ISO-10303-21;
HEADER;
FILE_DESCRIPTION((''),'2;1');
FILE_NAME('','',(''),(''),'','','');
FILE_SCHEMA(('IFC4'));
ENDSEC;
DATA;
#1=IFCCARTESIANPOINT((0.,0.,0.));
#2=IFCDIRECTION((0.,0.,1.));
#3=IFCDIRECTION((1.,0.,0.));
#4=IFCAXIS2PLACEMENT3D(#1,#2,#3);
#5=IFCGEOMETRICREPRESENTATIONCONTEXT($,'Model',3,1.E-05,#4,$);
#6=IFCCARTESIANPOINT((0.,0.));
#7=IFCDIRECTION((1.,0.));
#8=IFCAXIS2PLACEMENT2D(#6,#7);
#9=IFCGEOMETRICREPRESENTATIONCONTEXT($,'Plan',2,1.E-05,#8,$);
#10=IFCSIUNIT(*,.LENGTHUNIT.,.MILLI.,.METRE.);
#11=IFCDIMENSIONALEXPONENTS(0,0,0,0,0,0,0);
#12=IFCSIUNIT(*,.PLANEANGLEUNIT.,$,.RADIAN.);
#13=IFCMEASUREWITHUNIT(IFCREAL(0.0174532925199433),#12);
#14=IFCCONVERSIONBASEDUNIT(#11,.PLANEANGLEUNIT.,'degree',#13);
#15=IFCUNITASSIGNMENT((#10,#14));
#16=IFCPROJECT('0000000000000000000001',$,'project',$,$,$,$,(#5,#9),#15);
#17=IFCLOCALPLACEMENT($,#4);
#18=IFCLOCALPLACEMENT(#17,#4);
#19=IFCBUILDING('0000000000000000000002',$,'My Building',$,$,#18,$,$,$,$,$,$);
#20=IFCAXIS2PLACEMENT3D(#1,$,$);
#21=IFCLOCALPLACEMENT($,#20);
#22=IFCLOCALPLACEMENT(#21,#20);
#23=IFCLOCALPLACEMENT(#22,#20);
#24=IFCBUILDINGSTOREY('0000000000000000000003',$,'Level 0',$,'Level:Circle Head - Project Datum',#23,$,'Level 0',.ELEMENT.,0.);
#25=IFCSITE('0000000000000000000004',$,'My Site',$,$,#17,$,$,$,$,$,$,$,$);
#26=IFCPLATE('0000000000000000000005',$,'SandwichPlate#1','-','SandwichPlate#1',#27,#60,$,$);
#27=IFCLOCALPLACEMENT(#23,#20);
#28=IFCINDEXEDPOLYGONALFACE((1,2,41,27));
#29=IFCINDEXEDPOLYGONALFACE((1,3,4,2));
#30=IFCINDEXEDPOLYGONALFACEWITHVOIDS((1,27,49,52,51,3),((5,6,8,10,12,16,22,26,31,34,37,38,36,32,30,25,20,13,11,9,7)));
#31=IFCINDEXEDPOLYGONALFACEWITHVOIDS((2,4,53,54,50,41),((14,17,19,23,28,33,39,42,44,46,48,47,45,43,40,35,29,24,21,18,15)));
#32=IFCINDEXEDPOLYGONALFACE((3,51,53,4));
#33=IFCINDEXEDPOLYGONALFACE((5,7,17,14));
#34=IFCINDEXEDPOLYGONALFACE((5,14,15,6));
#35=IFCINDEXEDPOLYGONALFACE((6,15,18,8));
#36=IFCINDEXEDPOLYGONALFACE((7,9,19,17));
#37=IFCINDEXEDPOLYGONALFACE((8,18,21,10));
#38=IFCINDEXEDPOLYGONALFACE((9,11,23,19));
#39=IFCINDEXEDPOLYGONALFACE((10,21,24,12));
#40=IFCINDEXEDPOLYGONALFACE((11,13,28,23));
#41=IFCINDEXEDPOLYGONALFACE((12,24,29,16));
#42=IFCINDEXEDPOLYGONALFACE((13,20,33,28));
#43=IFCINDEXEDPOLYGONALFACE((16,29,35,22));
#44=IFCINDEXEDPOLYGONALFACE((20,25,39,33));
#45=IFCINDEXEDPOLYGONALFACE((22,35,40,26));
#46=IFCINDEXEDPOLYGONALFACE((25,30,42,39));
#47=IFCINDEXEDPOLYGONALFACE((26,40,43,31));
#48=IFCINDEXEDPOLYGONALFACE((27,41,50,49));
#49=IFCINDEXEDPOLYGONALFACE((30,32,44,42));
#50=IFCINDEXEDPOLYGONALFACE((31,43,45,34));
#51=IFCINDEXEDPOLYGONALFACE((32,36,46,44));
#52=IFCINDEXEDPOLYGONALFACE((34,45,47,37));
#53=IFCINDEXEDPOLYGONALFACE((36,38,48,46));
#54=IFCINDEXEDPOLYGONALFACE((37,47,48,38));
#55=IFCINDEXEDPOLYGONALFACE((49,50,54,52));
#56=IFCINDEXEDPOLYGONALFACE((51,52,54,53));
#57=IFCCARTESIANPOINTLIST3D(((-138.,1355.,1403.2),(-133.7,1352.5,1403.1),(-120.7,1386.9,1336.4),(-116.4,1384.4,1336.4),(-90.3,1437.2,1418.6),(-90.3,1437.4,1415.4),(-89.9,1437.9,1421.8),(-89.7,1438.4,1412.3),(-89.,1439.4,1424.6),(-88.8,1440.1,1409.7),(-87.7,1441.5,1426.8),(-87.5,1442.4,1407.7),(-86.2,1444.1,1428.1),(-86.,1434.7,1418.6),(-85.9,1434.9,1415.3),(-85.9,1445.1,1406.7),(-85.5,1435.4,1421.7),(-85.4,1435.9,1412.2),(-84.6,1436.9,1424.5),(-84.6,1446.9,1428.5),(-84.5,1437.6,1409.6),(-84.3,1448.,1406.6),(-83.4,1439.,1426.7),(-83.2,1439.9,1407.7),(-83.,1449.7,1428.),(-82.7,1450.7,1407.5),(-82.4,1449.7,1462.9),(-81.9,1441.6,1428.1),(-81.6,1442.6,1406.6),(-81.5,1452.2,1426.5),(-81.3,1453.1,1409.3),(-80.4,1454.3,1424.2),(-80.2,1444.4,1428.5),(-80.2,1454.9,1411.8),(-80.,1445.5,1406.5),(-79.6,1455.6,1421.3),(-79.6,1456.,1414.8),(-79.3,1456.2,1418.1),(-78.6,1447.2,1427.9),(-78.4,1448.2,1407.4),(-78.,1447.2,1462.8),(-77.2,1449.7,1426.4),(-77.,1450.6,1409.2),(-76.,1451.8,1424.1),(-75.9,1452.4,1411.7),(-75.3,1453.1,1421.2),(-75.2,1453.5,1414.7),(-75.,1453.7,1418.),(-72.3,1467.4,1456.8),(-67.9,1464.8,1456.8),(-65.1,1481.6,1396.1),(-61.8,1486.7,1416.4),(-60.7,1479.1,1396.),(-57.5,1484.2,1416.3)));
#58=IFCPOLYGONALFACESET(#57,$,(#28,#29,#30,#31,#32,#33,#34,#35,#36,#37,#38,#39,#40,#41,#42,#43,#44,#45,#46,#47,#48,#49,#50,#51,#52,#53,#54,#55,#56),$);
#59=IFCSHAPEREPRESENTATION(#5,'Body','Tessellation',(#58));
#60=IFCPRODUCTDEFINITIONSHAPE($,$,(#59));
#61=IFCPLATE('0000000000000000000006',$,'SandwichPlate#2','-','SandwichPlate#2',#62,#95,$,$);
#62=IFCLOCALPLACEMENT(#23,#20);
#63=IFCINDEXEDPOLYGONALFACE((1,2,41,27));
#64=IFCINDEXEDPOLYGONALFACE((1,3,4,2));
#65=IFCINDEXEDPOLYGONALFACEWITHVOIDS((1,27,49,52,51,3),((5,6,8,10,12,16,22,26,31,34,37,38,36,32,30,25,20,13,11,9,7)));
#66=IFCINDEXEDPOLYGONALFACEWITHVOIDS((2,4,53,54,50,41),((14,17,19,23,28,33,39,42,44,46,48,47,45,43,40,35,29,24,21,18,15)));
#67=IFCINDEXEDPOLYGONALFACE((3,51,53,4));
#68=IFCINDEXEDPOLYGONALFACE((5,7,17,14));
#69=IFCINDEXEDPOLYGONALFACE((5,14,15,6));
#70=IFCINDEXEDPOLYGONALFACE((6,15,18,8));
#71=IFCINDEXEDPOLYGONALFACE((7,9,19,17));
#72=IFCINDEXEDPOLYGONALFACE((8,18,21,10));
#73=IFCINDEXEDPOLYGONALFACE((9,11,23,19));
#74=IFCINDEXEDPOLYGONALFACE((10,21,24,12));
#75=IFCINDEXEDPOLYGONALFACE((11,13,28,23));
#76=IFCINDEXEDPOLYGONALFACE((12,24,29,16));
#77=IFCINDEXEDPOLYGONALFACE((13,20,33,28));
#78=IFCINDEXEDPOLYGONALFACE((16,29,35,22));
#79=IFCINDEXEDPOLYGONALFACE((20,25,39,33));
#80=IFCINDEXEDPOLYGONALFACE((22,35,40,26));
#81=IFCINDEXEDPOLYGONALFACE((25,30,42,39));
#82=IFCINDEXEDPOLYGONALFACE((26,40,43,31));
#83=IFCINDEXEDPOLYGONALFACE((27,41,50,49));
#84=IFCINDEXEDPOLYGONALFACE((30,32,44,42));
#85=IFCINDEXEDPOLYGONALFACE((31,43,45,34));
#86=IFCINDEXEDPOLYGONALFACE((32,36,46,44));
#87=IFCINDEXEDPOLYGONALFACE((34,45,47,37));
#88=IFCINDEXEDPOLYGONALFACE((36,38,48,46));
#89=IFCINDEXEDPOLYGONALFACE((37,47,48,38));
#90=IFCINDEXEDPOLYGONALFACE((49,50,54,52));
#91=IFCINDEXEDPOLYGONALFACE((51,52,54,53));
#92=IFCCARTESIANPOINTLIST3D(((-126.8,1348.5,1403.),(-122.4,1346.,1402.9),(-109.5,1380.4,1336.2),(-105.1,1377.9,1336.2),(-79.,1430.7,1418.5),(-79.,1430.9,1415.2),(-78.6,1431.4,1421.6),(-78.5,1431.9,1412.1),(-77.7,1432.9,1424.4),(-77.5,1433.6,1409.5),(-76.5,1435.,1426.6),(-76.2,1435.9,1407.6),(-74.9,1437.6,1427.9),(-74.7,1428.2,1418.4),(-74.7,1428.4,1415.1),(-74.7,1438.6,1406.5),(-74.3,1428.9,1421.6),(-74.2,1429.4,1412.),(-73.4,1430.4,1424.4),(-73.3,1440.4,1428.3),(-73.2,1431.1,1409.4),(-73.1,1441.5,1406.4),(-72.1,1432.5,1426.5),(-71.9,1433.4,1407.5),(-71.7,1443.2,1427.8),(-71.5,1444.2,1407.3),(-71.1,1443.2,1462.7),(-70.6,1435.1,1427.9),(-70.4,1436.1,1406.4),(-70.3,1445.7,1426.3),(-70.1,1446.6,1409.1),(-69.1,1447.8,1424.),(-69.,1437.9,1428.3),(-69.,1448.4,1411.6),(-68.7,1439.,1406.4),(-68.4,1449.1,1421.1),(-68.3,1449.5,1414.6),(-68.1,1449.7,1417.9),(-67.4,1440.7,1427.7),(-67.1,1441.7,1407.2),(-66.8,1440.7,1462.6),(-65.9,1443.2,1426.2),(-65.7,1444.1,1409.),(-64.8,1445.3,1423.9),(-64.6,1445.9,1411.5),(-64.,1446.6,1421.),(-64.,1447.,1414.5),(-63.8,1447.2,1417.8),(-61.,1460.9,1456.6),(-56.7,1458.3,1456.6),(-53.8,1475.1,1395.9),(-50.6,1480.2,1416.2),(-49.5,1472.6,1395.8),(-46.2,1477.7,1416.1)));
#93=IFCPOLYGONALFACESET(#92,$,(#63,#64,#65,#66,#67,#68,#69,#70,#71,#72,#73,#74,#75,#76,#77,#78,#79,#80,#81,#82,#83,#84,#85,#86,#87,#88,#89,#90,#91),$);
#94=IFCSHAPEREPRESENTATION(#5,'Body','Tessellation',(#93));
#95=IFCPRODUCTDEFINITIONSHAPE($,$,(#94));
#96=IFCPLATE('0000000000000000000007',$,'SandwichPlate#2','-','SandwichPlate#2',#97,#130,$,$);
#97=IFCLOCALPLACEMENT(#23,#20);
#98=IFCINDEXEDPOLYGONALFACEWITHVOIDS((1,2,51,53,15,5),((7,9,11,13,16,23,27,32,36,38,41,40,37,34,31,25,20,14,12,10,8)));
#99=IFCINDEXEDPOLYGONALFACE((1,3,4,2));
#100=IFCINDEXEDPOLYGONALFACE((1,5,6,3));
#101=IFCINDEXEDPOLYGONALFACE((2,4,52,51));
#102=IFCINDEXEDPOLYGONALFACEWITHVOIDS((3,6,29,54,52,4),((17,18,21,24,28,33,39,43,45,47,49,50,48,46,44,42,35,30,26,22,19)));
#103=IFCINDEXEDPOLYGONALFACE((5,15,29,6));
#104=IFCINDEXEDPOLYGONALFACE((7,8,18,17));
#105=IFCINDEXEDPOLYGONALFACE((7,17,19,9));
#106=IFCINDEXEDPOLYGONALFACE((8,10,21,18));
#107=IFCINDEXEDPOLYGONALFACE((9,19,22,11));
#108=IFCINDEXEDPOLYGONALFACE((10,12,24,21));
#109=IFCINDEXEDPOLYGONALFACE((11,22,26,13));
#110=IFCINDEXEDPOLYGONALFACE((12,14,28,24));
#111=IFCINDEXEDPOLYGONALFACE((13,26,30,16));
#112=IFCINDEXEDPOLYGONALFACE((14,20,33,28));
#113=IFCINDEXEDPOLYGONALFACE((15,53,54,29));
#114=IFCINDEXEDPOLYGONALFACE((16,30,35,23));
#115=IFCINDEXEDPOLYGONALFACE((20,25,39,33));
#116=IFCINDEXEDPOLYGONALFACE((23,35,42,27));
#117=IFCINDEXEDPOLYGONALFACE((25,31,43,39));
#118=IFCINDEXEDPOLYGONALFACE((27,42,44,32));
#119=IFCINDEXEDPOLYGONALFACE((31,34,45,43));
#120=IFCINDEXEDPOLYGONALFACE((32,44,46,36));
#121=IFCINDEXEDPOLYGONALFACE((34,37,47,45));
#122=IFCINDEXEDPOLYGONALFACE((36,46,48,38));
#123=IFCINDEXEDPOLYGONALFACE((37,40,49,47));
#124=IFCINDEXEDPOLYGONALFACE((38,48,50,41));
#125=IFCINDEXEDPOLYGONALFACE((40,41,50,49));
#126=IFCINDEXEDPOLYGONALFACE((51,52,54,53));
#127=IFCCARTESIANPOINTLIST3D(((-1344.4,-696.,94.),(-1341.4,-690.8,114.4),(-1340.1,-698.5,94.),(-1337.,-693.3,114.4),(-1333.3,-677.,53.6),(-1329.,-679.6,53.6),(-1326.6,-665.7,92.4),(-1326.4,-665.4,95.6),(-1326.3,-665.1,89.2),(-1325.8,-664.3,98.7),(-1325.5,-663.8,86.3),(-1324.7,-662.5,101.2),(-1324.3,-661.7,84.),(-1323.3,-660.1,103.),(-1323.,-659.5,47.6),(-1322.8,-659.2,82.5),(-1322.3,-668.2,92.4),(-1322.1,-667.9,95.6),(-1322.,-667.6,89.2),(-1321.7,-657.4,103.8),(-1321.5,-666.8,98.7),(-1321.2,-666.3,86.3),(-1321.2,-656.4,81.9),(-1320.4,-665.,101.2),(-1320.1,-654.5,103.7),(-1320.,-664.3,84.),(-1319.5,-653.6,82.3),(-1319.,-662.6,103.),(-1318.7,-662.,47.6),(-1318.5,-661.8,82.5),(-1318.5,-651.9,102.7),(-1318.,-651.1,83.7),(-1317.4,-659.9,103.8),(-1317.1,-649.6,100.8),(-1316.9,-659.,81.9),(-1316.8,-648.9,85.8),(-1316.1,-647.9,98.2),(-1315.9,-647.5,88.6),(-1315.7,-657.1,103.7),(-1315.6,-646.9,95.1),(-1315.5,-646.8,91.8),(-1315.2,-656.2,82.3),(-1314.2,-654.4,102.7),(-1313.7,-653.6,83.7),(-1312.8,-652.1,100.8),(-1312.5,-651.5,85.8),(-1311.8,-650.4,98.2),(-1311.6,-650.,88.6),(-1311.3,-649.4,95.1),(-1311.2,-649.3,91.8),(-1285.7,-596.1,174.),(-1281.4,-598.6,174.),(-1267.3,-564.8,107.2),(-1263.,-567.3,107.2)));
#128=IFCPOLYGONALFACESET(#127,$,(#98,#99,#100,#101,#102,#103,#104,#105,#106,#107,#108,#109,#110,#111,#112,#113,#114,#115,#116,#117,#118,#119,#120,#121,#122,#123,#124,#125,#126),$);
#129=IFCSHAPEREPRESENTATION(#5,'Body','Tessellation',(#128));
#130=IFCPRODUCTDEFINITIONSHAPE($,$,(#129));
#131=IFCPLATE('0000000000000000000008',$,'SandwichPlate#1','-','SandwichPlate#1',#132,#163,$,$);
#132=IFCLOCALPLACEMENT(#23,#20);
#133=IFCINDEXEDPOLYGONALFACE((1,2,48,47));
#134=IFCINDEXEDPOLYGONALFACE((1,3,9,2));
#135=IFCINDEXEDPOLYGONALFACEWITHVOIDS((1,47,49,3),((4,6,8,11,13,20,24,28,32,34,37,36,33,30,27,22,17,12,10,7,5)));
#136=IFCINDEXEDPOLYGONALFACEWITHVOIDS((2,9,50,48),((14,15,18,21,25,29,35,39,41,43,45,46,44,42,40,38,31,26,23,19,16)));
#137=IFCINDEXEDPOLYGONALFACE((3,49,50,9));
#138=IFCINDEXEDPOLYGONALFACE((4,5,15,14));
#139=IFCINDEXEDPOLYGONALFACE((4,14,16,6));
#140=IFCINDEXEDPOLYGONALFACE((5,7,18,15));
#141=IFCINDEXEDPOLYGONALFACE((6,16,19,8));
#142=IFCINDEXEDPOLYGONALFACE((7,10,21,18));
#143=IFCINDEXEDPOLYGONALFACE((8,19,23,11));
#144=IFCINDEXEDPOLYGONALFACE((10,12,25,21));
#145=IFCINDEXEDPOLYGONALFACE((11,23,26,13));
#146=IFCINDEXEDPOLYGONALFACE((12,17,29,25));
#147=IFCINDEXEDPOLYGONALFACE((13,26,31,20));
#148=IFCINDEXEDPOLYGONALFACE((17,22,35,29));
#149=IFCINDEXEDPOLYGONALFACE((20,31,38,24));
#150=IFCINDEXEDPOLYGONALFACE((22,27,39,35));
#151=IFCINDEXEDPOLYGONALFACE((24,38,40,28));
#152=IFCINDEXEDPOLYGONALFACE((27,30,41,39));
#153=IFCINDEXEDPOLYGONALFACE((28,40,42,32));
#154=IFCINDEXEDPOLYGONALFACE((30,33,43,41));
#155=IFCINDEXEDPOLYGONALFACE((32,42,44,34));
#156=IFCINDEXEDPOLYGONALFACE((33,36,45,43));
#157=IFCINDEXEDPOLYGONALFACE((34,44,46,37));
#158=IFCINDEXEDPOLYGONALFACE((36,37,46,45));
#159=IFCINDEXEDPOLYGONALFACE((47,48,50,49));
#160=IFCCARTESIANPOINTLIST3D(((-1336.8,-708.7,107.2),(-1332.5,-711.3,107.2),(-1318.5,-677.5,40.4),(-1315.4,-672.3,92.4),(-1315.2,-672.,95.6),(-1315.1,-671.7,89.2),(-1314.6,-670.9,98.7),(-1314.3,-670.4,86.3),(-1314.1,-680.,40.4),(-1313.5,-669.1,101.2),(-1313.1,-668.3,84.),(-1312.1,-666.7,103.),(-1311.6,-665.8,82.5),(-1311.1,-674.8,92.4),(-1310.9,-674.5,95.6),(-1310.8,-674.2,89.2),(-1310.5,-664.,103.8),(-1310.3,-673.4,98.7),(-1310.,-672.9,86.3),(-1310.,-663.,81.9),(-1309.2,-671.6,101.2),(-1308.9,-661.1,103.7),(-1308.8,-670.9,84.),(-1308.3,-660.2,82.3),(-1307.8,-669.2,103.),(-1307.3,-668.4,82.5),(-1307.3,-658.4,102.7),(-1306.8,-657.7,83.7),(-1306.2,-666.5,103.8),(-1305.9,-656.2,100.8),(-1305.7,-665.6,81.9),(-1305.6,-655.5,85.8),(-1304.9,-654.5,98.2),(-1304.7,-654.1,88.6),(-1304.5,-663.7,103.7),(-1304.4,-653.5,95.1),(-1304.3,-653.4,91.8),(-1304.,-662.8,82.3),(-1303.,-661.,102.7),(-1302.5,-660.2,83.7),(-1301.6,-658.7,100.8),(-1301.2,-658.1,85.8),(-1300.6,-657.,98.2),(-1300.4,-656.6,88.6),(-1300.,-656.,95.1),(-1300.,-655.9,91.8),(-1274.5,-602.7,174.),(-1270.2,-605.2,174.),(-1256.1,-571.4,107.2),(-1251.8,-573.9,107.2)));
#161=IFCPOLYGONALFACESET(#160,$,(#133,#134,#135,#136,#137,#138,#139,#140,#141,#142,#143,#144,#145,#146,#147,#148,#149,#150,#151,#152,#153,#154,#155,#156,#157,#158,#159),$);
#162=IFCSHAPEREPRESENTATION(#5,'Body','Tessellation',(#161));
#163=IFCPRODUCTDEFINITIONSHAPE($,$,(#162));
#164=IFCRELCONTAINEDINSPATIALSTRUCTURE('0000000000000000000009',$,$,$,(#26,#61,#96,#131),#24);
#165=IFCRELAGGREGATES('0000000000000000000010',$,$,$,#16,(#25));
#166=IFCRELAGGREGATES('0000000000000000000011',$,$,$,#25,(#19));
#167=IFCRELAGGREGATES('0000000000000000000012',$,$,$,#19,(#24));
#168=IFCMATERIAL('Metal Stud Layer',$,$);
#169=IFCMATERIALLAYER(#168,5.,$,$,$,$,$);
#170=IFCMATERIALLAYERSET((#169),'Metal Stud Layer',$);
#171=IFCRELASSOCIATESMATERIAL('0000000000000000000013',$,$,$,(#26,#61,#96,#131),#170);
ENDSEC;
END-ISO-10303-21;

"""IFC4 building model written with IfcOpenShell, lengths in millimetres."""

from ifc_helpers import new_model, entity, si_unit, converted_unit, frame, origin, origin_with_axes, origin_2d_with_axis, place, context, project, spatial, polyline, circle, outline, extrude, material, layer, layer_set, element, save


model = new_model("IFC4")

# Units and contexts
model_context = context("Model", 3, precision=1e-05, world=origin_with_axes())
plan_context = context("Plan", 2, precision=1e-05, world=origin_2d_with_axis())
ifc_project = project(units=[si_unit("LENGTHUNIT", "METRE", prefix="MILLI"), converted_unit("PLANEANGLEUNIT", "degree", entity("IfcReal", 0.0174532925199433), si_unit("PLANEANGLEUNIT", "RADIAN"), dimensions=[0, 0, 0, 0, 0, 0, 0])], contexts=[model_context, plan_context])

# Site, building, storey
site_placement = place(None, origin_with_axes())
site = spatial("IfcSite", under=ifc_project, at=site_placement, Name="My Site")
building_placement = place(site_placement, origin_with_axes())
building = spatial("IfcBuilding", under=site, at=building_placement, Name="My Building")
placement_1 = place(None, origin())
placement_2 = place(placement_1, origin())
storey_placement = place(placement_2, origin())
storey = spatial("IfcBuildingStorey", under=building, at=storey_placement, Name="Level 0", ObjectType="Level:Circle Head - Project Datum", LongName="Level 0", CompositionType="ELEMENT", Elevation=0.0)

# Plates, openings
ifc_material_1 = material(Name="Metal Stud Layer")
ifc_layer_1 = layer(ifc_material_1, 5.0)
ifc_layer_set_1 = layer_set([ifc_layer_1], Name="Metal Stud Layer")
plate_1_placement = place(storey_placement, frame((-58.4, 1493.0, 1403.2), z_axis=(0.865935, -0.499948, -0.014432), x_axis=(-0.22762, -0.419615, 0.878699)))
plate_1 = element("IfcPlate", 1, at=plate_1_placement, inside=storey, material=ifc_layer_set_1, Name="SandwichPlate#1", Description="-", ObjectType="SandwichPlate#1", context=model_context, shape_type="SweptSolid", body=[
    extrude(outline(polyline([(0.0, 0.0), (76.0, 0.0), (76.0, 140.0), (0.0, 140.0), (0.0, 0.0)])), origin_with_axes(), (0.0, 0.0, 1.0), 5.0),
])
opening_1_placement = place(plate_1_placement, frame((0.0, 0.0, 0.0), z_axis=(0.0, 0.0, 1.0), x_axis=(1.0, 0.0, 0.0)))
element("IfcOpeningElement", 2, at=opening_1_placement, cuts=plate_1, ObjectType="Opening", context=model_context, shape_type="SweptSolid", body=[
    extrude(outline(polyline([(0.0, 0.0), (15.0, 0.0), (0.0, 15.0), (0.0, 0.0)])), origin(), (0.0, 0.0, 1.0), 5.0),
])
opening_2_placement = place(plate_1_placement, frame((0.0, 0.0, 0.0), z_axis=(0.0, 0.0, 1.0), x_axis=(1.0, 0.0, 0.0)))
element("IfcOpeningElement", 3, at=opening_2_placement, cuts=plate_1, ObjectType="Opening", context=model_context, shape_type="SweptSolid", body=[
    extrude(outline(polyline([(76.0, 0.0), (76.0, 15.0), (61.0, 0.0), (76.0, 0.0)])), origin(), (0.0, 0.0, 1.0), 5.0),
])
opening_3_placement = place(plate_1_placement, frame((38.0, 40.0, -0.5), z_axis=(0.0, 0.0, 1.0), x_axis=(0.0, 1.0, 0.0)))
element("IfcOpeningElement", 4, at=opening_3_placement, cuts=plate_1, ObjectType="Opening", context=model_context, shape_type="SweptSolid", body=[
    extrude(circle(Radius=11.0, at=origin_2d_with_axis()), origin(), (0.0, 0.0, 1.0), 6.0),
])
plate_2_placement = place(storey_placement, frame((-47.1, 1486.5, 1403.0), z_axis=(0.865935, -0.499948, -0.014432), x_axis=(-0.22762, -0.419615, 0.878699)))
plate_2 = element("IfcPlate", 5, at=plate_2_placement, inside=storey, material=ifc_layer_set_1, Name="SandwichPlate#2", Description="-", ObjectType="SandwichPlate#2", context=model_context, shape_type="SweptSolid", body=[
    extrude(outline(polyline([(0.0, 0.0), (76.0, 0.0), (76.0, 140.0), (0.0, 140.0), (0.0, 0.0)])), origin_with_axes(), (0.0, 0.0, 1.0), 5.0),
])
opening_4_placement = place(plate_2_placement, frame((0.0, 0.0, 0.0), z_axis=(0.0, 0.0, 1.0), x_axis=(1.0, 0.0, 0.0)))
element("IfcOpeningElement", 6, at=opening_4_placement, cuts=plate_2, ObjectType="Opening", context=model_context, shape_type="SweptSolid", body=[
    extrude(outline(polyline([(0.0, 0.0), (15.0, 0.0), (0.0, 15.0), (0.0, 0.0)])), origin(), (0.0, 0.0, 1.0), 5.0),
])
opening_5_placement = place(plate_2_placement, frame((0.0, 0.0, 0.0), z_axis=(0.0, 0.0, 1.0), x_axis=(1.0, 0.0, 0.0)))
element("IfcOpeningElement", 7, at=opening_5_placement, cuts=plate_2, ObjectType="Opening", context=model_context, shape_type="SweptSolid", body=[
    extrude(outline(polyline([(76.0, 0.0), (76.0, 15.0), (61.0, 0.0), (76.0, 0.0)])), origin(), (0.0, 0.0, 1.0), 5.0),
])
opening_6_placement = place(plate_2_placement, frame((38.0, 40.0, -0.5), z_axis=(0.0, 0.0, 1.0), x_axis=(0.0, 1.0, 0.0)))
element("IfcOpeningElement", 8, at=opening_6_placement, cuts=plate_2, ObjectType="Opening", context=model_context, shape_type="SweptSolid", body=[
    extrude(circle(Radius=11.0, at=origin_2d_with_axis()), origin(), (0.0, 0.0, 1.0), 6.0),
])

# Plates, openings
plate_3_placement = place(storey_placement, frame((-1348.0, -702.1, 107.2), z_axis=(0.86208, -0.506772, 0.0), x_axis=(0.24181, 0.411348, -0.878818)))
plate_3 = element("IfcPlate", 9, at=plate_3_placement, inside=storey, material=ifc_layer_set_1, Name="SandwichPlate#2", Description="-", ObjectType="SandwichPlate#2", context=model_context, shape_type="SweptSolid", body=[
    extrude(outline(polyline([(15.0, 0.0), (61.0, 0.0), (76.0, 15.0), (76.0, 140.0), (0.0, 140.0), (0.0, 15.0), (15.0, 0.0)])), origin_with_axes(), (0.0, 0.0, 1.0), 5.0),
])
opening_7_placement = place(plate_3_placement, frame((38.0, 40.0, -0.5), z_axis=(0.0, 0.0, 1.0), x_axis=(0.0, 1.0, 0.0)))
element("IfcOpeningElement", 10, at=opening_7_placement, cuts=plate_3, ObjectType="Opening", context=model_context, shape_type="SweptSolid", body=[
    extrude(circle(Radius=11.0, at=origin_2d_with_axis()), origin(), (0.0, 0.0, 1.0), 6.0),
])
plate_4_placement = place(storey_placement, frame((-1336.8, -708.7, 107.2), z_axis=(0.86208, -0.506772, 0.0), x_axis=(0.24181, 0.411348, -0.878818)))
plate_4 = element("IfcPlate", 11, at=plate_4_placement, inside=storey, material=ifc_layer_set_1, Name="SandwichPlate#1", Description="-", ObjectType="SandwichPlate#1", context=model_context, shape_type="SweptSolid", body=[
    extrude(outline(polyline([(0.0, 0.0), (76.0, 0.0), (76.0, 140.0), (0.0, 140.0), (0.0, 0.0)])), origin_with_axes(), (0.0, 0.0, 1.0), 5.0),
])
opening_8_placement = place(plate_4_placement, frame((38.0, 40.0, -0.5), z_axis=(0.0, 0.0, 1.0), x_axis=(0.0, 1.0, 0.0)))
element("IfcOpeningElement", 12, at=opening_8_placement, cuts=plate_4, ObjectType="Opening", context=model_context, shape_type="SweptSolid", body=[
    extrude(circle(Radius=11.0, at=origin_2d_with_axis()), origin(), (0.0, 0.0, 1.0), 6.0),
])

save(model, "model.ifc")
